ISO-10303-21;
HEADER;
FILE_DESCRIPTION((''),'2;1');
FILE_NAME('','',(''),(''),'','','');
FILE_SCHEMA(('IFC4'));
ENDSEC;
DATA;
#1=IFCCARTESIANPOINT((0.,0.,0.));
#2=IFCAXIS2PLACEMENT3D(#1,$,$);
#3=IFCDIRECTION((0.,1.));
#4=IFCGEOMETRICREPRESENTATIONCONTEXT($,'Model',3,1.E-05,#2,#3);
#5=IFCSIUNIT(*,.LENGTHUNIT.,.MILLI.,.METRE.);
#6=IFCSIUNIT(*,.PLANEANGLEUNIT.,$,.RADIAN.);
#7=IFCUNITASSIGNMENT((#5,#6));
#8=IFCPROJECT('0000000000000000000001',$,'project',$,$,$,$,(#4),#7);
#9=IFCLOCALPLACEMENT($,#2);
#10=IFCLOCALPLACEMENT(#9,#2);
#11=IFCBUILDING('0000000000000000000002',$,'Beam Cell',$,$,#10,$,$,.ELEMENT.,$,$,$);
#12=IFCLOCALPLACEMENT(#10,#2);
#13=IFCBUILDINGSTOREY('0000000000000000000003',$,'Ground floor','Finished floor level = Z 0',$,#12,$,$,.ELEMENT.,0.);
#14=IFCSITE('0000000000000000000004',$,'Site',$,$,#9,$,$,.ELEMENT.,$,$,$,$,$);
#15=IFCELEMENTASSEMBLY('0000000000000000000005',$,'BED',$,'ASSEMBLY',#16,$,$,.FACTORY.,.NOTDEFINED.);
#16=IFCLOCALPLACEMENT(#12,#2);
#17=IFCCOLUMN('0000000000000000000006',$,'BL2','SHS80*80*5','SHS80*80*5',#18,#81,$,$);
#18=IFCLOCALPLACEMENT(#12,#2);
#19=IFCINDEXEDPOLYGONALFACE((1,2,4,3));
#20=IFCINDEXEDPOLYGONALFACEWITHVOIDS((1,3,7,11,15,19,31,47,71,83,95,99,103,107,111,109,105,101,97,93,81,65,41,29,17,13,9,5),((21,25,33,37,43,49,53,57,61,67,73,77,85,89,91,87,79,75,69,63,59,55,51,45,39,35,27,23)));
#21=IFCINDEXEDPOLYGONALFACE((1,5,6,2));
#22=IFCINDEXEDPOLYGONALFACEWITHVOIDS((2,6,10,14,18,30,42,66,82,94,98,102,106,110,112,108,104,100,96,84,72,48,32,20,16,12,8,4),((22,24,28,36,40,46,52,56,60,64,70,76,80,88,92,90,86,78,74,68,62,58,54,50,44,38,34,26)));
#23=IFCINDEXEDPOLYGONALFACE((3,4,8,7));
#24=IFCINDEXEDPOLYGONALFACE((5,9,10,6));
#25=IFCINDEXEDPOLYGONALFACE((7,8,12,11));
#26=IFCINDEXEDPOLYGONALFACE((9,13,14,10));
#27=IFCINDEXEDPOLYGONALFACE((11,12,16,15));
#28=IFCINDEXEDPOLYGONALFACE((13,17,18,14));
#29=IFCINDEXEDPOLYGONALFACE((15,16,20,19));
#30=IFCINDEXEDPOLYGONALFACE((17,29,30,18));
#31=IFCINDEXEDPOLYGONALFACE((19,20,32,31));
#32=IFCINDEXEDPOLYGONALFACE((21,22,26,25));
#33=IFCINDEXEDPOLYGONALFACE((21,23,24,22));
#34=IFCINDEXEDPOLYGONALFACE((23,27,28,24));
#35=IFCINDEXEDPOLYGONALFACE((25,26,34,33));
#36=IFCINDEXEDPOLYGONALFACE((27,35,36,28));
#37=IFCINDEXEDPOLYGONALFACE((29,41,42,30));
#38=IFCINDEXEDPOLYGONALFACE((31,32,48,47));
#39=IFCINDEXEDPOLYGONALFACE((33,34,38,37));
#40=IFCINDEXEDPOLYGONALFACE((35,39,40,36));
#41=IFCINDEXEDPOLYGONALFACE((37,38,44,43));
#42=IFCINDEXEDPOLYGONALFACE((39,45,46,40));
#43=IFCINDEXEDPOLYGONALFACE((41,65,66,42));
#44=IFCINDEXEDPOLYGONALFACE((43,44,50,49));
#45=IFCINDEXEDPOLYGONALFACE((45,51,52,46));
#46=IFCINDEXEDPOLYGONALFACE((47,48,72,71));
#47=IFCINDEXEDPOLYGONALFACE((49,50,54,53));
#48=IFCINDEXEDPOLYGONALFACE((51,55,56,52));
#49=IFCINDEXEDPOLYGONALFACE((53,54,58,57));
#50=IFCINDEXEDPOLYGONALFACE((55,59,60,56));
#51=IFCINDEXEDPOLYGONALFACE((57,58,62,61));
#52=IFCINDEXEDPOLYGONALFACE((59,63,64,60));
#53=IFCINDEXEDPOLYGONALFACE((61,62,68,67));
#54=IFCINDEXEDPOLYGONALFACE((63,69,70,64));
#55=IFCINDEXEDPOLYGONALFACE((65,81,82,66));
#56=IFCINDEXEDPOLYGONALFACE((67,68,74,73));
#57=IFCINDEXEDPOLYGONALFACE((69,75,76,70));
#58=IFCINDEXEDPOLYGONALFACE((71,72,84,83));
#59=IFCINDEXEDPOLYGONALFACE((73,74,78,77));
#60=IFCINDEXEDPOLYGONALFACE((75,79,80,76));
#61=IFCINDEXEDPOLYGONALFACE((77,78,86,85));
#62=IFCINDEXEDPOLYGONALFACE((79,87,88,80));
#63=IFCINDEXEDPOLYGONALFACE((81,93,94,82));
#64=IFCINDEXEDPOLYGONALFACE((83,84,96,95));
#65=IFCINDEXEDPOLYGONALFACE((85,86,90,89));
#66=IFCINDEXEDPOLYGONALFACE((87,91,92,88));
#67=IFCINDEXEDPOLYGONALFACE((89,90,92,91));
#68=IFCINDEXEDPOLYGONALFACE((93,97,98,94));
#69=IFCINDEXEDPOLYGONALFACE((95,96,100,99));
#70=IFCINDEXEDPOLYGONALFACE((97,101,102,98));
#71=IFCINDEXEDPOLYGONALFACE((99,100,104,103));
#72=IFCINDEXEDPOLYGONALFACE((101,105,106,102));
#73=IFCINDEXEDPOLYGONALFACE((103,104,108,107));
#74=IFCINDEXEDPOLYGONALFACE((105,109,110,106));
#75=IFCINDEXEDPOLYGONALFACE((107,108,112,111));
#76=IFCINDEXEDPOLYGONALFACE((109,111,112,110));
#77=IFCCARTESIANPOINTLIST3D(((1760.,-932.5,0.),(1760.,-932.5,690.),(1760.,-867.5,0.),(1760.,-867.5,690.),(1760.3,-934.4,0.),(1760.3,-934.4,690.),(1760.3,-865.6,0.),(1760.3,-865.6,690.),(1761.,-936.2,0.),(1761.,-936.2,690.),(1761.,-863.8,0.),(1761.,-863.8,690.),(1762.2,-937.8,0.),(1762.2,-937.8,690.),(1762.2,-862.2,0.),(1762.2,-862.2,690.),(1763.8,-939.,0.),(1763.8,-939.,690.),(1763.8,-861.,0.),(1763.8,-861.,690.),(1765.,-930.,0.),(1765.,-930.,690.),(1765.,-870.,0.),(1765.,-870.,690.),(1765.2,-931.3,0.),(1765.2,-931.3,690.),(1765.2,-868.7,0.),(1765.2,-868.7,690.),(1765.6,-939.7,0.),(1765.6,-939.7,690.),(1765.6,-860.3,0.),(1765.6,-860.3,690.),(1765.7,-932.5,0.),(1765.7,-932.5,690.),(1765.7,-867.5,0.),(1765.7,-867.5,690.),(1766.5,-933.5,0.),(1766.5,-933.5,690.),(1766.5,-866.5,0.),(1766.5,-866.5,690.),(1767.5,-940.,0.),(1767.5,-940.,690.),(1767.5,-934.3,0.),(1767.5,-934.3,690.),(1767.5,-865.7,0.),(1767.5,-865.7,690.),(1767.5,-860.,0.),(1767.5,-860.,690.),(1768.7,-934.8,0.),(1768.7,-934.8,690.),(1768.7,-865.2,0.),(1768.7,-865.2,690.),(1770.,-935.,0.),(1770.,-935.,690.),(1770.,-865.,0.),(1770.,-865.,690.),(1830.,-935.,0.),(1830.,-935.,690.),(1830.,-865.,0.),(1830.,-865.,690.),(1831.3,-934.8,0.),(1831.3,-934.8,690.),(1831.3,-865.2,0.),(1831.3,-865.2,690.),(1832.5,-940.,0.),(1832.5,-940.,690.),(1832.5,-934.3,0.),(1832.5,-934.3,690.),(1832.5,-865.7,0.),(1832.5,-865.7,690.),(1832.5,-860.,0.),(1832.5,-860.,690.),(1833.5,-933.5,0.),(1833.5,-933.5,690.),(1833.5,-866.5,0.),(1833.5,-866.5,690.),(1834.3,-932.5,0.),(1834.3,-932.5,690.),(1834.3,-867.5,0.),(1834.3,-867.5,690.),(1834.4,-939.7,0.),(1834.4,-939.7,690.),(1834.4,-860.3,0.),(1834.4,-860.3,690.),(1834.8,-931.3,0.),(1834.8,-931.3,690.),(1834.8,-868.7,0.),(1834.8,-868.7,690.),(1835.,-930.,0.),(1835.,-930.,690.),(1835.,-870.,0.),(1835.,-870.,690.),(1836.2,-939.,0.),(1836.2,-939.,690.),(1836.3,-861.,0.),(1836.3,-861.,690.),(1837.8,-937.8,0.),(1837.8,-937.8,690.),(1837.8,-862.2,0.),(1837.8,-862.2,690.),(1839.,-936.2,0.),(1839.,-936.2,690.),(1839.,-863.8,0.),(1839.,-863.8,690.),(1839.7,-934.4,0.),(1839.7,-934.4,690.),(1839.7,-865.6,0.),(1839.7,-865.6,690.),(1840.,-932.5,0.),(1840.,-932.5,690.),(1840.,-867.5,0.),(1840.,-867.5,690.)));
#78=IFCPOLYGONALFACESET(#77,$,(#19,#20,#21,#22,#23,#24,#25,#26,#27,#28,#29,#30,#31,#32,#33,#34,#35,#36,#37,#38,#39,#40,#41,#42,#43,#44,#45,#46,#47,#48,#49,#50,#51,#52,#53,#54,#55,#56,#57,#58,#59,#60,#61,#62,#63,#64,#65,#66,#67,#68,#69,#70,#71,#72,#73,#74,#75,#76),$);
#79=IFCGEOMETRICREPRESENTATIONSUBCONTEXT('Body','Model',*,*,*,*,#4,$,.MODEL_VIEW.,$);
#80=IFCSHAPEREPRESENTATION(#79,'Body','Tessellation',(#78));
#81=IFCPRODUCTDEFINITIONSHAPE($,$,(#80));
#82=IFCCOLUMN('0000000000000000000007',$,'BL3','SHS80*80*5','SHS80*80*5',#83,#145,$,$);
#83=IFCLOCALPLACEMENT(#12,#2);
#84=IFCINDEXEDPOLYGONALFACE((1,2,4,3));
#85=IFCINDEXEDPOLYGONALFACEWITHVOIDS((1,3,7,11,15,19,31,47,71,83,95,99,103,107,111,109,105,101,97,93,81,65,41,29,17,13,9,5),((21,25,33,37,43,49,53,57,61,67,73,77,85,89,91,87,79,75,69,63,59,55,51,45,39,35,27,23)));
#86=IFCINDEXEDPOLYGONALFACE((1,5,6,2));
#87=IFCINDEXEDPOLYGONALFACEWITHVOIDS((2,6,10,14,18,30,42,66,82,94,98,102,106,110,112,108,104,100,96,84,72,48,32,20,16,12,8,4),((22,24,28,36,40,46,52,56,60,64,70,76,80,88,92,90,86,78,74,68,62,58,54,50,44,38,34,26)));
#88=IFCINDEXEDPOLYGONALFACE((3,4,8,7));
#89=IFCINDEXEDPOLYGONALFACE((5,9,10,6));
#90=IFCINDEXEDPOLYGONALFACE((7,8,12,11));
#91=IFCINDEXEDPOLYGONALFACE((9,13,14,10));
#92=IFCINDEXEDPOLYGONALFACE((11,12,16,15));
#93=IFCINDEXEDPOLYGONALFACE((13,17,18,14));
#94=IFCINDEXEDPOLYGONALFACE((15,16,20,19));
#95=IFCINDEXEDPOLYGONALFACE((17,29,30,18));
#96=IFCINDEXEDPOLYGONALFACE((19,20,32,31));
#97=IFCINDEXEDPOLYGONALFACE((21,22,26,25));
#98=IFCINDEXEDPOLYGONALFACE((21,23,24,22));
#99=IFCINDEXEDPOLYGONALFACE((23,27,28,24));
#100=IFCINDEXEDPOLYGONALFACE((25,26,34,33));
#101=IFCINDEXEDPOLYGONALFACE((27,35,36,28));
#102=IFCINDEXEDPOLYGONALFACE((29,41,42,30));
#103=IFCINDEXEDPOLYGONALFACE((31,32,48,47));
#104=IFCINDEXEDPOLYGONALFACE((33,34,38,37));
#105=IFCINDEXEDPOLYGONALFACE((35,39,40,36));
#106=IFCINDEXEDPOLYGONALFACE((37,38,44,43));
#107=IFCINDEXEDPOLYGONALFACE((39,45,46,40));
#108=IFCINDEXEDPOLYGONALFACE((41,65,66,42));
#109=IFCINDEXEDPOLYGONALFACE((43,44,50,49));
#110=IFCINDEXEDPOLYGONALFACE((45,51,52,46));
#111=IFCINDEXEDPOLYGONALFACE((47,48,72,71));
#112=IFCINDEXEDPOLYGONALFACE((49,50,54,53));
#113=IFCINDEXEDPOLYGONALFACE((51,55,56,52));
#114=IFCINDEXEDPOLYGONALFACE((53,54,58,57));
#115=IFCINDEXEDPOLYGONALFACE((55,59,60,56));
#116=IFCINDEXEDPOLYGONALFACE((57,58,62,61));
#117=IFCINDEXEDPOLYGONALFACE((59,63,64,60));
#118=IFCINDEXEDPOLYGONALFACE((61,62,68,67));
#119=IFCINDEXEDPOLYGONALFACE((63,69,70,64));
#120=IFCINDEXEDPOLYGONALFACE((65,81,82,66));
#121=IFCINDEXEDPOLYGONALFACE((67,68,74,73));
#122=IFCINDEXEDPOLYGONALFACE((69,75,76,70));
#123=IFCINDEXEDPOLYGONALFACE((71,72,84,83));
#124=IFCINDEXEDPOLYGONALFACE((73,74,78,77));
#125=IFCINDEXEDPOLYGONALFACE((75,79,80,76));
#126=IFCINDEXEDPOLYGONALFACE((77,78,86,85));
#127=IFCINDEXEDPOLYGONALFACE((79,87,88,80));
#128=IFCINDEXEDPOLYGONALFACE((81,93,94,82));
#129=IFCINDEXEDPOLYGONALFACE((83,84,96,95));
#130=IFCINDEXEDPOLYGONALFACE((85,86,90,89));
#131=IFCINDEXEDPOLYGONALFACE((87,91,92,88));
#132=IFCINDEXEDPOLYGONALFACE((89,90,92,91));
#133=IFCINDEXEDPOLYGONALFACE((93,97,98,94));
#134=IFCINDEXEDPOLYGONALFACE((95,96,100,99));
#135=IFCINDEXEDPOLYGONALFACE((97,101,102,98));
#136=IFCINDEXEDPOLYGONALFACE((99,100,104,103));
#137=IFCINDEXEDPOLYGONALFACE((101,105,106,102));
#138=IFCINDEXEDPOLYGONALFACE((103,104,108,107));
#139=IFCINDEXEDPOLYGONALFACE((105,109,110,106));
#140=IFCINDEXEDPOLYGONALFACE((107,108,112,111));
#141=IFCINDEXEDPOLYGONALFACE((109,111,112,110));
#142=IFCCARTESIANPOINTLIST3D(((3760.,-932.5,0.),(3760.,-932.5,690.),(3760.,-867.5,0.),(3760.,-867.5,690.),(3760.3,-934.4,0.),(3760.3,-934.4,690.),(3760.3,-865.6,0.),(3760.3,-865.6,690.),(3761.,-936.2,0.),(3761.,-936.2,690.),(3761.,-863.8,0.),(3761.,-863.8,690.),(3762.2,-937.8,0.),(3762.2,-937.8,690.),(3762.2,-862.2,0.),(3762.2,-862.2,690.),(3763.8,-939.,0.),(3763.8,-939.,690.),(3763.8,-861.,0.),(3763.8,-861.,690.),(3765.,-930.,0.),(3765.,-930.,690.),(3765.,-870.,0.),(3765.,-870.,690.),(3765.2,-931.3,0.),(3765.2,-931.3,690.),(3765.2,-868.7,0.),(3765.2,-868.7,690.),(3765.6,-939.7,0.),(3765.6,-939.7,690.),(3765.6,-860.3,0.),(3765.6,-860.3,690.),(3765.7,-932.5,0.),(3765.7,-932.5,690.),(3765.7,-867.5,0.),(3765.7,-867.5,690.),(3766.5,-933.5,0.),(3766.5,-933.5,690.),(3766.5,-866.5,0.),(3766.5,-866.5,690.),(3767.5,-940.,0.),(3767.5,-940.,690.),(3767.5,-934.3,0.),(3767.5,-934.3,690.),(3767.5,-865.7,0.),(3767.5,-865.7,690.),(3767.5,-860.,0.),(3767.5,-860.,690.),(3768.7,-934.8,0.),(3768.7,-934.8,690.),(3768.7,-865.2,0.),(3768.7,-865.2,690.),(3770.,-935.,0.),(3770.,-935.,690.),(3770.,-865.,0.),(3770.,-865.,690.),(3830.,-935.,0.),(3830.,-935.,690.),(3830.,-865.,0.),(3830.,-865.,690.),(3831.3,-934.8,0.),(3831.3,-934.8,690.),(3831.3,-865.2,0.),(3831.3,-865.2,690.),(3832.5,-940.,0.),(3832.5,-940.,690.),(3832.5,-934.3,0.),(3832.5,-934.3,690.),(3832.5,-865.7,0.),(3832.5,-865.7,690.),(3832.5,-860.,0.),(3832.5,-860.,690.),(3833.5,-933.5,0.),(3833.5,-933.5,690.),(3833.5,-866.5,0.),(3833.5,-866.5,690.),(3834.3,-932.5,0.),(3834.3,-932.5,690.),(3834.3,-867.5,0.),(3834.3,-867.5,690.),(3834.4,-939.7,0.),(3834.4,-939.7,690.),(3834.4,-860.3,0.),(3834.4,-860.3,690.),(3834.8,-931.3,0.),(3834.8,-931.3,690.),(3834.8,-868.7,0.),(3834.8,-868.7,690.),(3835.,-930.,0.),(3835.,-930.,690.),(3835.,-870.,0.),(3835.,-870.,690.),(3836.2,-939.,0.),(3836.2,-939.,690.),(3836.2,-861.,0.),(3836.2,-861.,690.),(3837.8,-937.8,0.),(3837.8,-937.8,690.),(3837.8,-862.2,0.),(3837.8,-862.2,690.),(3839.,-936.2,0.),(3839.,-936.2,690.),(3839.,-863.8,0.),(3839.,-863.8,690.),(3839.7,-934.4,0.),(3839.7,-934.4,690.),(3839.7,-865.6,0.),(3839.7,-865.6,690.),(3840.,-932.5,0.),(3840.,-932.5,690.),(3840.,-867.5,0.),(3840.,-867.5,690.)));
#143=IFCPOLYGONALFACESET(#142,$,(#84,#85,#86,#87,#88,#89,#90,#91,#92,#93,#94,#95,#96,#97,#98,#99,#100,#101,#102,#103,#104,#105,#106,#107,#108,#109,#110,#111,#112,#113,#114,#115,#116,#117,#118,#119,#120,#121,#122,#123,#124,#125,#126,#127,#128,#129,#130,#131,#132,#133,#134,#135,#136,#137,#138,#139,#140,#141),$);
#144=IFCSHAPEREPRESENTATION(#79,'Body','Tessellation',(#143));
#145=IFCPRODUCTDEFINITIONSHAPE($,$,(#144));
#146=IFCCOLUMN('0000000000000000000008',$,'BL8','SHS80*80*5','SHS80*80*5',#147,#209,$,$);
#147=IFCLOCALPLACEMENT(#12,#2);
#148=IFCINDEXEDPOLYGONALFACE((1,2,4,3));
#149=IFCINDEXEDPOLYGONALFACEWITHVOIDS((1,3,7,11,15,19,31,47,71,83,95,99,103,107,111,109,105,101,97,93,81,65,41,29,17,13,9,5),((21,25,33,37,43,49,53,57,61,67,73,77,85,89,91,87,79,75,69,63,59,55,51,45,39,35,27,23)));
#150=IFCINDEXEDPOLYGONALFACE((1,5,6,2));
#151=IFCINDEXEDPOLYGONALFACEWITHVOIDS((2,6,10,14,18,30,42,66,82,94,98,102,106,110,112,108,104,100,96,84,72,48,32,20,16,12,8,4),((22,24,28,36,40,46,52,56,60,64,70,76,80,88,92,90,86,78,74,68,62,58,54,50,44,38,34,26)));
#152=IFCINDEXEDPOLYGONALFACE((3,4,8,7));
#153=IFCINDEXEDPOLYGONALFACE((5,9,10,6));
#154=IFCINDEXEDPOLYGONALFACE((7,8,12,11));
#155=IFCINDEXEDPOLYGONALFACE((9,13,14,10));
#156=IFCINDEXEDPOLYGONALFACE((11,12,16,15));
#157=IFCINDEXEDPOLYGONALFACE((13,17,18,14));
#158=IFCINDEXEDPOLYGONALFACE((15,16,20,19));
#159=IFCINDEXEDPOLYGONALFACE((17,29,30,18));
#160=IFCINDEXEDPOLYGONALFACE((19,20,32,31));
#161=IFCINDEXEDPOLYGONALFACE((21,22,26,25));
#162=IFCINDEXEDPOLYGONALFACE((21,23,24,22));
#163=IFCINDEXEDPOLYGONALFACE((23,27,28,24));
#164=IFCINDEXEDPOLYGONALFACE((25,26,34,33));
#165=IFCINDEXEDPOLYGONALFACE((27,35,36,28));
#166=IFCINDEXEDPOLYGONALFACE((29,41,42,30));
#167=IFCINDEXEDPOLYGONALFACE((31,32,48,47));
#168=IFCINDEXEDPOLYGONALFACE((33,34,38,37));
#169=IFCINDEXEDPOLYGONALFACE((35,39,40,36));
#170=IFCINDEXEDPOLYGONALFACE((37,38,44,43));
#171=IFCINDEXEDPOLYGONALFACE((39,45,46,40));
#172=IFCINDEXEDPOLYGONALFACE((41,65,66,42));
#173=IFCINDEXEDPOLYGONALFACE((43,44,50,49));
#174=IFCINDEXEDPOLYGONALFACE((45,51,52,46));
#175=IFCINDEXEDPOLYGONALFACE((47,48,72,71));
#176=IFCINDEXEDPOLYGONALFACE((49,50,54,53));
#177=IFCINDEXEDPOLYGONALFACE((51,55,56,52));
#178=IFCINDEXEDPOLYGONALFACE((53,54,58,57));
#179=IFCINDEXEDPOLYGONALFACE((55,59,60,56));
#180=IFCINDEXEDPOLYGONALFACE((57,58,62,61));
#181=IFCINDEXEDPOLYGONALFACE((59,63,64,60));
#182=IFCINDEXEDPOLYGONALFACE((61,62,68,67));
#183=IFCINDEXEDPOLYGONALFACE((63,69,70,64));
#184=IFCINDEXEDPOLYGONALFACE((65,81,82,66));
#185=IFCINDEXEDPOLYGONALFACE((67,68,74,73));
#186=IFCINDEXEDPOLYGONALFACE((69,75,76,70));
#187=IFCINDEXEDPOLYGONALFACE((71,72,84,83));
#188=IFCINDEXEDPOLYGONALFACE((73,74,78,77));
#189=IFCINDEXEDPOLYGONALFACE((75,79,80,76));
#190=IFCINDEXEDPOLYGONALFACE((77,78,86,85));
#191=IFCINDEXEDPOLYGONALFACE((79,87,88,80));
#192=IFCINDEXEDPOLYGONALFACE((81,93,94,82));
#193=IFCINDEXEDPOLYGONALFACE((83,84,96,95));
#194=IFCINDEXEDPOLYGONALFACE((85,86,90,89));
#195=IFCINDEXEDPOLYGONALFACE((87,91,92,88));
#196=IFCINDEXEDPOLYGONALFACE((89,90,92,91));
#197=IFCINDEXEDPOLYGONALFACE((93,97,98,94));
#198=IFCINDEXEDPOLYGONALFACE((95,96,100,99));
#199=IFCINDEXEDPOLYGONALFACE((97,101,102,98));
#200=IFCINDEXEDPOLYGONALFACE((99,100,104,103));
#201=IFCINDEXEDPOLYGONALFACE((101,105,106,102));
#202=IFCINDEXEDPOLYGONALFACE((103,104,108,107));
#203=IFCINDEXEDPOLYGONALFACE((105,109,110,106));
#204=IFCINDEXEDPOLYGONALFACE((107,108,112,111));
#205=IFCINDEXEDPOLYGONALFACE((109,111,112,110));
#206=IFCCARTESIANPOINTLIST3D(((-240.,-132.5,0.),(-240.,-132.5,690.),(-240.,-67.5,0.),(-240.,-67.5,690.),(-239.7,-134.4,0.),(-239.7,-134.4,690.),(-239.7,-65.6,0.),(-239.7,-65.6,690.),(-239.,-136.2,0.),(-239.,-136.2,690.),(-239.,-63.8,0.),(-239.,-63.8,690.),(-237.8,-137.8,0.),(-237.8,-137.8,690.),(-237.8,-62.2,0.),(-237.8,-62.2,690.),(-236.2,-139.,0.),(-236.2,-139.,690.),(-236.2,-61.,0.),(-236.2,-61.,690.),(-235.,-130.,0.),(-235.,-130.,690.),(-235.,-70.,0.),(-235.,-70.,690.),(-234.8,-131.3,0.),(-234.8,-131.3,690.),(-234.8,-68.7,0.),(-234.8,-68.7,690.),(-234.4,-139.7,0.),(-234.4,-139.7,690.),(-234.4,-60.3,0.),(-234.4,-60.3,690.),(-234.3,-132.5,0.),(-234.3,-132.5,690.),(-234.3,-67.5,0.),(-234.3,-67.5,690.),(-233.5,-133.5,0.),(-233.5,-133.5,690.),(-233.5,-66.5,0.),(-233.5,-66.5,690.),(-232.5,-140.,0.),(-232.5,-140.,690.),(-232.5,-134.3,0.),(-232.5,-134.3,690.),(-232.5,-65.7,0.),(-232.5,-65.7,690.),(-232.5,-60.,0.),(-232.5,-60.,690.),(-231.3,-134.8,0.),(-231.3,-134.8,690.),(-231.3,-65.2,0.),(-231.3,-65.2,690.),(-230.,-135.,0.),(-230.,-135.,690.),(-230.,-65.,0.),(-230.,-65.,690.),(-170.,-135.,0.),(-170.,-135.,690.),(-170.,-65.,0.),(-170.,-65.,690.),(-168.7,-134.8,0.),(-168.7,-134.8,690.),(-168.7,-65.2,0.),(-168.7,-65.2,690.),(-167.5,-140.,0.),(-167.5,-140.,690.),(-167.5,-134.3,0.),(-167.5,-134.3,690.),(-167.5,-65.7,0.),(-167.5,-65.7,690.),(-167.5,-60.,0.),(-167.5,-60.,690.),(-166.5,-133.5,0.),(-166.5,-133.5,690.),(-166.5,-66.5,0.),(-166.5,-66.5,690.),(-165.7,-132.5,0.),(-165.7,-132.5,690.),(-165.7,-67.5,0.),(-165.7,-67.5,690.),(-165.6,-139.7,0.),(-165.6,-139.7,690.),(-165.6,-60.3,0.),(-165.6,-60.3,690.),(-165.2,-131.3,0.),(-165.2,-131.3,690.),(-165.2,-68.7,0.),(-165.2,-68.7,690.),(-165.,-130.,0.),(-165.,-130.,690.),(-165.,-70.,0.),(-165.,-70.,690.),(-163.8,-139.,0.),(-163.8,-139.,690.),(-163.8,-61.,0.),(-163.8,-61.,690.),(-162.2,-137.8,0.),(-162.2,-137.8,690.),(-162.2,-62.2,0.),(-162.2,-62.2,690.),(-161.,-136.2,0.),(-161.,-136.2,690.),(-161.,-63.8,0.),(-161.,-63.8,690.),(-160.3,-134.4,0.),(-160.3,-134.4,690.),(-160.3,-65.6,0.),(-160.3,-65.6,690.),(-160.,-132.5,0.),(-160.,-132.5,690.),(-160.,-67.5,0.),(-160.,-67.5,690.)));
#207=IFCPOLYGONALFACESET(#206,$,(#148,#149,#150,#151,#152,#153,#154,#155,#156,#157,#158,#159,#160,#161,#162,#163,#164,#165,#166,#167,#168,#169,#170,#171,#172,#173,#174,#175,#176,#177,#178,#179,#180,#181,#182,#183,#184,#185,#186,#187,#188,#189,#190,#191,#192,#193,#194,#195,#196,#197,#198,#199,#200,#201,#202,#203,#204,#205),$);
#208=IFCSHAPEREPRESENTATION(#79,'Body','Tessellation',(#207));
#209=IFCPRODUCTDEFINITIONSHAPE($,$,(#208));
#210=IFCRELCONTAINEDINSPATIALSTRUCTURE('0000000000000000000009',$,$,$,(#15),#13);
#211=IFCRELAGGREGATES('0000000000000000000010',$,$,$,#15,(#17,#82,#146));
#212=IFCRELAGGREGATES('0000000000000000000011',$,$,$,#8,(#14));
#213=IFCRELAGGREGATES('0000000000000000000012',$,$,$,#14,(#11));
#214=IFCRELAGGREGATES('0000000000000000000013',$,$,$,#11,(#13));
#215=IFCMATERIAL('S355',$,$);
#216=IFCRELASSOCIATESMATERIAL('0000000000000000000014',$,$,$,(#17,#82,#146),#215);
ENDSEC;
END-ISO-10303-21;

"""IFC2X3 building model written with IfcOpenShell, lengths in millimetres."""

from ifc_helpers import new_model, si_unit, direction, frame, origin, origin_2d, place, context, subcontext, project, spatial, hollow_rectangle, extrude, material, element, aggregate, save


model = new_model("IFC2X3")

# Units and contexts
model_context = context("Model", 3, precision=1e-05, world=origin(), true_north=direction((0.0, 1.0)))
body_context = subcontext(model_context, "Body", "Model", "MODEL_VIEW")
ifc_project = project(units=[si_unit("LENGTHUNIT", "METRE", prefix="MILLI"), si_unit("PLANEANGLEUNIT", "RADIAN")], contexts=[model_context])

# Site, building, storey
site_placement = place(None, origin())
site = spatial("IfcSite", under=ifc_project, at=site_placement, Name="Site", CompositionType="ELEMENT")
building_placement = place(site_placement, origin())
building = spatial("IfcBuilding", under=site, at=building_placement, Name="Beam Cell", CompositionType="ELEMENT")
storey_placement = place(building_placement, origin())
storey = spatial("IfcBuildingStorey", under=building, at=storey_placement, Name="Ground floor", Description="Finished floor level = Z 0", CompositionType="ELEMENT", Elevation=0.0)

# Shared definitions
ifc_material = material(Name="S355")

# Element assembly, columns
assembly_1_placement = place(storey_placement, origin())
assembly_1 = element("IfcElementAssembly", 1, at=assembly_1_placement, inside=storey, Name="BED", ObjectType="ASSEMBLY", AssemblyPlace="FACTORY", PredefinedType="NOTDEFINED")
column_1_placement = place(storey_placement, frame((1800.0, -900.0, 0.0), z_axis=(0.0, 0.0, 1.0), x_axis=(1.0, 0.0, 0.0)))
column_1 = element("IfcColumn", 2, at=column_1_placement, material=ifc_material, Name="BL2", Description="SHS80*80*5", ObjectType="SHS80*80*5", context=body_context, shape_type="SweptSolid", body=[
    extrude(hollow_rectangle(XDim=80.0, YDim=80.0, WallThickness=5.0, InnerFilletRadius=5.0, OuterFilletRadius=7.5, at=origin_2d()), origin(), (0.0, 0.0, 1.0), 690.0),
])
column_2_placement = place(storey_placement, frame((3800.0, -900.0, 0.0), z_axis=(0.0, 0.0, 1.0), x_axis=(1.0, 0.0, 0.0)))
column_2 = element("IfcColumn", 3, at=column_2_placement, material=ifc_material, Name="BL3", Description="SHS80*80*5", ObjectType="SHS80*80*5", context=body_context, shape_type="SweptSolid", body=[
    extrude(hollow_rectangle(XDim=80.0, YDim=80.0, WallThickness=5.0, InnerFilletRadius=5.0, OuterFilletRadius=7.5, at=origin_2d()), origin(), (0.0, 0.0, 1.0), 690.0),
])
column_3_placement = place(storey_placement, frame((-200.0, -100.0, 0.0), z_axis=(0.0, 0.0, 1.0), x_axis=(1.0, 0.0, 0.0)))
column_3 = element("IfcColumn", 4, at=column_3_placement, material=ifc_material, Name="BL8", Description="SHS80*80*5", ObjectType="SHS80*80*5", context=body_context, shape_type="SweptSolid", body=[
    extrude(hollow_rectangle(XDim=80.0, YDim=80.0, WallThickness=5.0, InnerFilletRadius=5.0, OuterFilletRadius=7.5, at=origin_2d()), origin(), (0.0, 0.0, 1.0), 690.0),
])
aggregate(assembly_1, [column_1, column_2, column_3])

save(model, "model.ifc")
